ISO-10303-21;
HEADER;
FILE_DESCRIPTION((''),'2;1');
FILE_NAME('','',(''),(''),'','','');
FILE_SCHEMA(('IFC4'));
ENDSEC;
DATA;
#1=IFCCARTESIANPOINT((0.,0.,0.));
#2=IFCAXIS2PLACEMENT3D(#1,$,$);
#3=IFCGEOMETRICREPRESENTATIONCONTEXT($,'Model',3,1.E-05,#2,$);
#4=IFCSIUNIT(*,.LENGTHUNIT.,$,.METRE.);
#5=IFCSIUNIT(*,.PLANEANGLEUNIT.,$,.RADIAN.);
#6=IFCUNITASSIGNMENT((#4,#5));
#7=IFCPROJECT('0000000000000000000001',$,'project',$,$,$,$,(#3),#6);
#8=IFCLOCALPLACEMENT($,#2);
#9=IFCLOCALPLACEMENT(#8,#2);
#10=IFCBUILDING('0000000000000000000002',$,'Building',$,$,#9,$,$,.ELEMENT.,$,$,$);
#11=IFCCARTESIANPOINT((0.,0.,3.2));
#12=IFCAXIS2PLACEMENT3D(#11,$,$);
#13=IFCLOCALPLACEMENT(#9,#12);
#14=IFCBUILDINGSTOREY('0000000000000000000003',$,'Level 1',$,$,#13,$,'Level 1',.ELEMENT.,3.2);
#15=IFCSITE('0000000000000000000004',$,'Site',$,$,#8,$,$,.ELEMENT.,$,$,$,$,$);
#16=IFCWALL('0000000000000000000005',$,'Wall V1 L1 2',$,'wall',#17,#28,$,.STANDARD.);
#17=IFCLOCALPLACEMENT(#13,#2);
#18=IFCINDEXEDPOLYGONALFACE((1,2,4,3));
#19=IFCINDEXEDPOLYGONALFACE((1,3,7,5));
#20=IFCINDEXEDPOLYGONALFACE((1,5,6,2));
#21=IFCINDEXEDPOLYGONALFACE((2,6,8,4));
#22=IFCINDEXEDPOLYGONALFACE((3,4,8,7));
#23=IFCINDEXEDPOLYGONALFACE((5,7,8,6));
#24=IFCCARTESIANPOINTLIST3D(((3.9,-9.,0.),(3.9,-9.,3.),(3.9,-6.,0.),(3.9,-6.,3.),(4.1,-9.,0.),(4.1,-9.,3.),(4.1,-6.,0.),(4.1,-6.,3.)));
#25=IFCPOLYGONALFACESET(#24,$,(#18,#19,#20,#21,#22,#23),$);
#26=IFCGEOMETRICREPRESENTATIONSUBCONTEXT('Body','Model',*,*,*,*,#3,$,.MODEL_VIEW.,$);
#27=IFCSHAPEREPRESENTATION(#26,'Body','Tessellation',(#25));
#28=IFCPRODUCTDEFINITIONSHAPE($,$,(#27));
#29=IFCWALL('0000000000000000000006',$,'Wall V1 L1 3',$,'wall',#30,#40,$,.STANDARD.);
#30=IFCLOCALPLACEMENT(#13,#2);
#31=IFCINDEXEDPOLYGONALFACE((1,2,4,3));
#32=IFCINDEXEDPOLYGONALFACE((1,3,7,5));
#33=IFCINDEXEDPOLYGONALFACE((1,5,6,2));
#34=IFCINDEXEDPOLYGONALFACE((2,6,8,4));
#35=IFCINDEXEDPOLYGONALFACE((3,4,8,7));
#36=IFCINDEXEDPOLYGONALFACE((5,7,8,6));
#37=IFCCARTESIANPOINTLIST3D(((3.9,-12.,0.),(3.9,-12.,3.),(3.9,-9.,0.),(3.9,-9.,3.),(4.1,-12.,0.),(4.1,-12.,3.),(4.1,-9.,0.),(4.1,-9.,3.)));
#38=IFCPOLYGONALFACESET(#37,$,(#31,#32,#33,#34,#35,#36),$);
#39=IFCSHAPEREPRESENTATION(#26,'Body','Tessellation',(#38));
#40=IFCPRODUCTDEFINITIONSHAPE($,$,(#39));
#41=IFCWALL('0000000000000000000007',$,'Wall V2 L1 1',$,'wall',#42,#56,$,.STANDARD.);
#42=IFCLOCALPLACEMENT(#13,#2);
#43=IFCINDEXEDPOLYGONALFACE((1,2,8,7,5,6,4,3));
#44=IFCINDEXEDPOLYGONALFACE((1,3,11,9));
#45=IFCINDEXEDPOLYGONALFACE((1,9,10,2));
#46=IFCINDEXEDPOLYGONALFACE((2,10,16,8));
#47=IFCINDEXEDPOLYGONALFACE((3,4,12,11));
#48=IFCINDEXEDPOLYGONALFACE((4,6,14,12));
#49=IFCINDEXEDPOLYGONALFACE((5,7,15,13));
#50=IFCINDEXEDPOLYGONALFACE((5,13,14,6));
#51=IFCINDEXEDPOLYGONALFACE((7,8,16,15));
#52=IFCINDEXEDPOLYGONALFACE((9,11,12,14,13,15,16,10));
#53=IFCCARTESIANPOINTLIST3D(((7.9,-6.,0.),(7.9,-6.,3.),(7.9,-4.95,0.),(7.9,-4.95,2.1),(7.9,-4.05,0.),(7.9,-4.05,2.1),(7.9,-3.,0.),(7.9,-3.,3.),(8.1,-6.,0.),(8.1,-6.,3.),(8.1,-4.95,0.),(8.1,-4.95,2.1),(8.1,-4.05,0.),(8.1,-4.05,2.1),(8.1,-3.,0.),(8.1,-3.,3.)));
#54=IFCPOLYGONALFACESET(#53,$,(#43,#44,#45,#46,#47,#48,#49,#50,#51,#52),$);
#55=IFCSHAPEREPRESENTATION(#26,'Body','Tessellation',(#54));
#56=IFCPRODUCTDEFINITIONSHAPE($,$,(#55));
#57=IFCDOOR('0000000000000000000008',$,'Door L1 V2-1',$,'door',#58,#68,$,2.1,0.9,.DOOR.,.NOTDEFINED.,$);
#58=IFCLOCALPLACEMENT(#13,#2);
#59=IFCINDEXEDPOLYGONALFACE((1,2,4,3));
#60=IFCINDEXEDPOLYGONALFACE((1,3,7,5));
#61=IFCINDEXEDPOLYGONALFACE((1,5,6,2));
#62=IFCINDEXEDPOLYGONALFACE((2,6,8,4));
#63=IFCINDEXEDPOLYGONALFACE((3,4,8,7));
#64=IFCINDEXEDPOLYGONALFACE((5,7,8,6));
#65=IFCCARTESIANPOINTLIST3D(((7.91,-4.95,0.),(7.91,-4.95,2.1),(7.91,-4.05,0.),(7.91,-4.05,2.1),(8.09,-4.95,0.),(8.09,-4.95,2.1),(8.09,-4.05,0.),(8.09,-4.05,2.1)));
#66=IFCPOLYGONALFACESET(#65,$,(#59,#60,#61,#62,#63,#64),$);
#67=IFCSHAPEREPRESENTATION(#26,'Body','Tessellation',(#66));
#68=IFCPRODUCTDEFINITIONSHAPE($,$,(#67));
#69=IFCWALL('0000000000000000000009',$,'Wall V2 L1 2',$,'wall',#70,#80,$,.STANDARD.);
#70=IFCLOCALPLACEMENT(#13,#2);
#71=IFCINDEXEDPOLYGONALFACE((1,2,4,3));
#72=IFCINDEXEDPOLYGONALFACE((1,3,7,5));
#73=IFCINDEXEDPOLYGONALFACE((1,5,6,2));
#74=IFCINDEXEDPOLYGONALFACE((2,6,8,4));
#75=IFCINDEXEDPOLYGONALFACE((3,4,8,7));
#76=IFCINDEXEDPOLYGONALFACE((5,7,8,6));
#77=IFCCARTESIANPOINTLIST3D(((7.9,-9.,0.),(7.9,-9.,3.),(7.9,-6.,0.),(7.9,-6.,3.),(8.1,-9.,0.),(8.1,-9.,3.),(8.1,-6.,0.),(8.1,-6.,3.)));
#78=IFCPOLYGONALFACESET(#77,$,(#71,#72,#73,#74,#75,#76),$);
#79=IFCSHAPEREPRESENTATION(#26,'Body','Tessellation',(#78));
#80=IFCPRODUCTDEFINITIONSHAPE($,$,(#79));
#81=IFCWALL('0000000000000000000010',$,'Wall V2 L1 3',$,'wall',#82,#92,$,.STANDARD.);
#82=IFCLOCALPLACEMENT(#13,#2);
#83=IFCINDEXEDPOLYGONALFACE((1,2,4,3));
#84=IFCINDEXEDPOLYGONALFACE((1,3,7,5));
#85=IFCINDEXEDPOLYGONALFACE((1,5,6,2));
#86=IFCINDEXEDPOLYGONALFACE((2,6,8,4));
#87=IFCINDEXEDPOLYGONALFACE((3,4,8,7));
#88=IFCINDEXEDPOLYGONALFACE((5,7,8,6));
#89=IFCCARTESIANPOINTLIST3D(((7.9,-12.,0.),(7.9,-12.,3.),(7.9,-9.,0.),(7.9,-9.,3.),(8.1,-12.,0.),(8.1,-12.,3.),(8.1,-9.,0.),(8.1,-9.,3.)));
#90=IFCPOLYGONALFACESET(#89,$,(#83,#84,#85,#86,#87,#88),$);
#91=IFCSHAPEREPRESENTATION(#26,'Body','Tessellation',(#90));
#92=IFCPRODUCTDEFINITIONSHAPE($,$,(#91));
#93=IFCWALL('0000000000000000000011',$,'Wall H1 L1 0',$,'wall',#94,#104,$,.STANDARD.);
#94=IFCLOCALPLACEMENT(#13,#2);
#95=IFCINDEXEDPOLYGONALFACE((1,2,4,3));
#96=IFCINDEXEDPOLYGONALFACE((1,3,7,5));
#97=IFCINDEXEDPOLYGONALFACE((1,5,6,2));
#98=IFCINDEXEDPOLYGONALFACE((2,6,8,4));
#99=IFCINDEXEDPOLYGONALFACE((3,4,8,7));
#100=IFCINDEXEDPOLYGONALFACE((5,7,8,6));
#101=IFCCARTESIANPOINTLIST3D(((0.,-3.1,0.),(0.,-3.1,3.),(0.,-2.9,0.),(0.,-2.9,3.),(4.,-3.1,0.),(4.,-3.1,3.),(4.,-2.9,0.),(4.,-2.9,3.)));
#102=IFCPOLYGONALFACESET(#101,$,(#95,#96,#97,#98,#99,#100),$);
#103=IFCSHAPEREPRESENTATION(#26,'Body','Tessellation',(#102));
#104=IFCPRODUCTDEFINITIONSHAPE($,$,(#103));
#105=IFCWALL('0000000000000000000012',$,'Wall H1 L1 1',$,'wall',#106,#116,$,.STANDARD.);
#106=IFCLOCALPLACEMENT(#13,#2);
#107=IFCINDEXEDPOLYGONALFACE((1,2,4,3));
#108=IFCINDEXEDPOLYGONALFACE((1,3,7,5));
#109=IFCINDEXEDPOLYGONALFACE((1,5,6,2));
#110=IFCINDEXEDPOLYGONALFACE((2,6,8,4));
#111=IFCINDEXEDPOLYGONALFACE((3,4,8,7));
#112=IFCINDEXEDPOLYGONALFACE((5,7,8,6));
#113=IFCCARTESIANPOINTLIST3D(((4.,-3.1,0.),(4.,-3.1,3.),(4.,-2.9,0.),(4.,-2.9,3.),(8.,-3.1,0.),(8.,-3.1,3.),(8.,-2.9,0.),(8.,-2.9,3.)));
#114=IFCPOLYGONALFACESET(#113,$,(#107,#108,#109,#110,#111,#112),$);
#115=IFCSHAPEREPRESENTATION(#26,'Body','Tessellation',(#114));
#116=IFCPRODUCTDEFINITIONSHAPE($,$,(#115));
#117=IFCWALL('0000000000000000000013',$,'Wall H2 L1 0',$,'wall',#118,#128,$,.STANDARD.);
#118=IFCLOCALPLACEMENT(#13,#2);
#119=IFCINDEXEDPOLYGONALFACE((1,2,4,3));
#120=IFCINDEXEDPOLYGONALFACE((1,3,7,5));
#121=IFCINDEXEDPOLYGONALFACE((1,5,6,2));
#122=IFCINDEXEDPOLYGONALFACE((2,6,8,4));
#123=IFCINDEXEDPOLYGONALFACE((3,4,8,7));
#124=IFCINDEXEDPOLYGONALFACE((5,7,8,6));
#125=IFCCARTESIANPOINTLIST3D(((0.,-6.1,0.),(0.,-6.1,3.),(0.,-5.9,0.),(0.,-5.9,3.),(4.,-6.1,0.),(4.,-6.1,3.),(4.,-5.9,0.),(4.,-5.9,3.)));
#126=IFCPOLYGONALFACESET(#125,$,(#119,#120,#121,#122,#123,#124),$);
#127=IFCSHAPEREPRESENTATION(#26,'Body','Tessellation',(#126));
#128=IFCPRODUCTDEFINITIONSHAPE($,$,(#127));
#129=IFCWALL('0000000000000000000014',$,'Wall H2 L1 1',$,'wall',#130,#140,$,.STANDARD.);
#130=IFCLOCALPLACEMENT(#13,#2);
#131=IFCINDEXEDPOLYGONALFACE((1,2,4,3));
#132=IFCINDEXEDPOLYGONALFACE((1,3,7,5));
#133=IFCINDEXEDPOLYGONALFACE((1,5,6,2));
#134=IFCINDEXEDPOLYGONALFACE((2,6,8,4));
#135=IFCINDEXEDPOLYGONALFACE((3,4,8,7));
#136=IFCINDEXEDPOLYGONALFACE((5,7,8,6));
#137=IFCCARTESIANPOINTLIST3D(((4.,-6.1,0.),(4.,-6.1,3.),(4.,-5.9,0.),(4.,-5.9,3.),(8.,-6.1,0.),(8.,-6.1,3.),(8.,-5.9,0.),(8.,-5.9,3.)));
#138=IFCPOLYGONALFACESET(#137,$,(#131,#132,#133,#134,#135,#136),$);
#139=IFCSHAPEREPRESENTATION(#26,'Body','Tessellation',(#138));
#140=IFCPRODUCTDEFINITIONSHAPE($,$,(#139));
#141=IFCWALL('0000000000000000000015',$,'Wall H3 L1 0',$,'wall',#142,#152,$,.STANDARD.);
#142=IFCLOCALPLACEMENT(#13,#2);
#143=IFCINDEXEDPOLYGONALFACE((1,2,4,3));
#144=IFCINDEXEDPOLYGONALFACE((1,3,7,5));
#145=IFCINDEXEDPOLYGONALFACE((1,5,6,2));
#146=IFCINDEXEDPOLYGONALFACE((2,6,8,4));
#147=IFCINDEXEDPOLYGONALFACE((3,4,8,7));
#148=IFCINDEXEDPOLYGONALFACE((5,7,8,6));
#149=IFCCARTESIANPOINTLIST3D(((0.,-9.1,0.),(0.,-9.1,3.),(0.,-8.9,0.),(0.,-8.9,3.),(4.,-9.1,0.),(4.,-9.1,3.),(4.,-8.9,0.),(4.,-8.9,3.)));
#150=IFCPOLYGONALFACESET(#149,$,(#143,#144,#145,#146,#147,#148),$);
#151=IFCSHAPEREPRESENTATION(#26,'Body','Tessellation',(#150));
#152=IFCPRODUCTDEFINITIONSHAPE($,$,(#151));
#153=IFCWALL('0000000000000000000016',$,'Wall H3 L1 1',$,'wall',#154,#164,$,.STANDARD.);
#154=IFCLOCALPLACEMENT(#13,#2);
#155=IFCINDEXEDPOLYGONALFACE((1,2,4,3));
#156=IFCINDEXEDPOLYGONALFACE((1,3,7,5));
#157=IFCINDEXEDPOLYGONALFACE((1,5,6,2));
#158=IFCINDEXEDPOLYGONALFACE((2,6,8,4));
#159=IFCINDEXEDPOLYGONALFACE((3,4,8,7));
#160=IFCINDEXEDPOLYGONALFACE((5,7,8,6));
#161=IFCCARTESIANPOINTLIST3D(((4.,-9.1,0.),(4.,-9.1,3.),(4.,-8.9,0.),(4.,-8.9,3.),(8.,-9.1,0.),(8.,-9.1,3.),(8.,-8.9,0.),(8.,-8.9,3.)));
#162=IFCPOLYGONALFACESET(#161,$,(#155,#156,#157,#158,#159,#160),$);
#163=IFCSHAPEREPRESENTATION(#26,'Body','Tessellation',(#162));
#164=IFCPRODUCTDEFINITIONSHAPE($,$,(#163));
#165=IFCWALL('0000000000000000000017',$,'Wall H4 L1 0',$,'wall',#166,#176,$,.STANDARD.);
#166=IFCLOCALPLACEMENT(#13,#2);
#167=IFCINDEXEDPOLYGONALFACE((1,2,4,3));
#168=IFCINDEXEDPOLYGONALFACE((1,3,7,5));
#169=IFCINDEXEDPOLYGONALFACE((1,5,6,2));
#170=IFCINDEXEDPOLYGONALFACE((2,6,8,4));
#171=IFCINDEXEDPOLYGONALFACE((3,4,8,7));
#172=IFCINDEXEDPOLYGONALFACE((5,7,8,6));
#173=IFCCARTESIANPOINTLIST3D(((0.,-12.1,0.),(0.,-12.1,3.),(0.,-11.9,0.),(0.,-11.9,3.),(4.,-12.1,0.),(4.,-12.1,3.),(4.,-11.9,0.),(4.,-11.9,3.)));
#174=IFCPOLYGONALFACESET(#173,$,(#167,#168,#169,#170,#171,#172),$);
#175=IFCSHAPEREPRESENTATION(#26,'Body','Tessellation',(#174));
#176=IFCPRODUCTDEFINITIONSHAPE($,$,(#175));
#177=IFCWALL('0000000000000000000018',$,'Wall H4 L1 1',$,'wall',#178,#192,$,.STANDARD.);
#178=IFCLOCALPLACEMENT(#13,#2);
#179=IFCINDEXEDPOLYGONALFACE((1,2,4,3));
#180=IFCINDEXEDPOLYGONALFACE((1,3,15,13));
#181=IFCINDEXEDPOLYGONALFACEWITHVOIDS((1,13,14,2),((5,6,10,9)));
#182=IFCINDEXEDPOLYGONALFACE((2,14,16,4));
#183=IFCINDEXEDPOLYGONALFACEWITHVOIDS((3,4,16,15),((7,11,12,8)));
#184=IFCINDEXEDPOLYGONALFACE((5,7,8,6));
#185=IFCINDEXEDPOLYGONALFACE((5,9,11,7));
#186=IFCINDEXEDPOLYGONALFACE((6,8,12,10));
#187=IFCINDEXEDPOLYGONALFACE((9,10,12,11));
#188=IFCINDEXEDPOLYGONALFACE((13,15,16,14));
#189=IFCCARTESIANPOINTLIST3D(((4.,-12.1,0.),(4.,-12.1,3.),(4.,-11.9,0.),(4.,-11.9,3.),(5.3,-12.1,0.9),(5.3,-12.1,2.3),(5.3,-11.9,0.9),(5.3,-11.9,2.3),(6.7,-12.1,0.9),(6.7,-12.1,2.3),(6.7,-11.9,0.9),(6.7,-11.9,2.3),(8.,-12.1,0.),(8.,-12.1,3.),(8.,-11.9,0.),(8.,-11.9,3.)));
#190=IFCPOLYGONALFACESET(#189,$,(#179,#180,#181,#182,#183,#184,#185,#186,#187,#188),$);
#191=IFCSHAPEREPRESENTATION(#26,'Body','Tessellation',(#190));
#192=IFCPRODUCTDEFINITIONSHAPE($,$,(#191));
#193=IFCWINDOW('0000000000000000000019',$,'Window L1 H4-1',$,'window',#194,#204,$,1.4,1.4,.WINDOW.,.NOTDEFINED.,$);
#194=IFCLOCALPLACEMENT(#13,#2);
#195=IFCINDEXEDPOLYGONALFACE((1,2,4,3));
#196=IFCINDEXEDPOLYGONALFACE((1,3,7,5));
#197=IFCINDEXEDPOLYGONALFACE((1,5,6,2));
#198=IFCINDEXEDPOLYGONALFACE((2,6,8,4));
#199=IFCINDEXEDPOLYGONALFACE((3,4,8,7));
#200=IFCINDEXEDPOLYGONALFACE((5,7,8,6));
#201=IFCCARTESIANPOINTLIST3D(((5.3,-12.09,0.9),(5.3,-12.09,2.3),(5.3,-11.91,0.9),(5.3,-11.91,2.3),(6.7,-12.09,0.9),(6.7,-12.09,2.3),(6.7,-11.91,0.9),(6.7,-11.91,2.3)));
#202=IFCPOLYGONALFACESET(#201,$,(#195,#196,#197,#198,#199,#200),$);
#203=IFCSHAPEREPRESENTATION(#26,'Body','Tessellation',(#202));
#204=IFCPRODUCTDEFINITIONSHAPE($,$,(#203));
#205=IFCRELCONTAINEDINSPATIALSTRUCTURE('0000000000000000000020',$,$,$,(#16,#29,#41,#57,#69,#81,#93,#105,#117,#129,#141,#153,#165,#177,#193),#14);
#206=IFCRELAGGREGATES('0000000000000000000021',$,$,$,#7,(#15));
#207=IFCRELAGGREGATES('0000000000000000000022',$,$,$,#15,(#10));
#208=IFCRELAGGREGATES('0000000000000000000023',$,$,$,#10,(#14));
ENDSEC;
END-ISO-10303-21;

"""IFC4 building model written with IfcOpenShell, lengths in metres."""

from ifc_helpers import new_model, si_unit, frame, frame_2d, origin, origin_2d, place, context, subcontext, project, spatial, rectangle, extrude, element, fill, save


model = new_model("IFC4")

# Units and contexts
model_context = context("Model", 3, precision=1e-05, world=origin())
body_context = subcontext(model_context, "Body", "Model", "MODEL_VIEW")
ifc_project = project(units=[si_unit("LENGTHUNIT", "METRE"), si_unit("PLANEANGLEUNIT", "RADIAN")], contexts=[model_context])

# Site, building, storey
site_placement = place(None, origin())
site = spatial("IfcSite", under=ifc_project, at=site_placement, Name="Site", CompositionType="ELEMENT")
building_placement = place(site_placement, origin())
building = spatial("IfcBuilding", under=site, at=building_placement, Name="Building", CompositionType="ELEMENT")
storey_placement = place(building_placement, frame((0.0, 0.0, 3.2)))
storey = spatial("IfcBuildingStorey", under=building, at=storey_placement, Name="Level 1", LongName="Level 1", CompositionType="ELEMENT", Elevation=3.2)

# Walls
for number, where, z_axis, x_axis, name in (
    (1, (4.0, -6.0, 0.0), (0.0, 0.0, 1.0), (0.0, -1.0, 0.0), "Wall V1 L1 2"),
    (2, (4.0, -9.0, 0.0), (0.0, 0.0, 1.0), (0.0, -1.0, 0.0), "Wall V1 L1 3"),
):
    element("IfcWall", number, at=place(storey_placement, frame(where, z_axis=z_axis, x_axis=x_axis)), inside=storey, Name=name, ObjectType="wall", PredefinedType="STANDARD", context=body_context, shape_type="SweptSolid", body=[
        extrude(rectangle(XDim=3.0, YDim=0.2, at=frame_2d((1.5, 0.0))), origin(), (0.0, 0.0, 1.0), 3.0),
    ])

# Wall, opening, door
wall_1_placement = place(storey_placement, frame((8.0, -3.0, 0.0), z_axis=(0.0, 0.0, 1.0), x_axis=(0.0, -1.0, 0.0)))
wall_1 = element("IfcWall", 3, at=wall_1_placement, inside=storey, Name="Wall V2 L1 1", ObjectType="wall", PredefinedType="STANDARD", context=body_context, shape_type="SweptSolid", body=[
    extrude(rectangle(XDim=3.0, YDim=0.2, at=frame_2d((1.5, 0.0))), origin(), (0.0, 0.0, 1.0), 3.0),
])
opening_1_placement = place(storey_placement, frame((8.0, -4.5, 0.0), z_axis=(0.0, 0.0, 1.0), x_axis=(0.0, -1.0, 0.0)))
opening_1 = element("IfcOpeningElement", 4, at=opening_1_placement, cuts=wall_1, ObjectType="Opening", PredefinedType="OPENING", context=body_context, shape_type="SweptSolid", body=[
    extrude(rectangle(XDim=0.9, YDim=0.22, at=origin_2d()), origin(), (0.0, 0.0, 1.0), 2.1),
])
door_1_placement = place(storey_placement, frame((8.0, -4.5, 0.0), z_axis=(0.0, 0.0, 1.0), x_axis=(0.0, -1.0, 0.0)))
door_1 = element("IfcDoor", 5, at=door_1_placement, inside=storey, Name="Door L1 V2-1", ObjectType="door", OperationType="NOTDEFINED", OverallHeight=2.1, OverallWidth=0.9, PredefinedType="DOOR", context=body_context, shape_type="SweptSolid", body=[
    extrude(rectangle(XDim=0.9, YDim=0.18, at=origin_2d()), origin(), (0.0, 0.0, 1.0), 2.1),
])
fill(opening_1, door_1)

# Walls
for number, where, z_axis, x_axis, name in (
    (6, (8.0, -6.0, 0.0), (0.0, 0.0, 1.0), (0.0, -1.0, 0.0), "Wall V2 L1 2"),
    (7, (8.0, -9.0, 0.0), (0.0, 0.0, 1.0), (0.0, -1.0, 0.0), "Wall V2 L1 3"),
):
    element("IfcWall", number, at=place(storey_placement, frame(where, z_axis=z_axis, x_axis=x_axis)), inside=storey, Name=name, ObjectType="wall", PredefinedType="STANDARD", context=body_context, shape_type="SweptSolid", body=[
        extrude(rectangle(XDim=3.0, YDim=0.2, at=frame_2d((1.5, 0.0))), origin(), (0.0, 0.0, 1.0), 3.0),
    ])
for number, where, z_axis, x_axis, name in (
    (8, (0.0, -3.0, 0.0), (0.0, 0.0, 1.0), (1.0, 0.0, 0.0), "Wall H1 L1 0"),
    (9, (4.0, -3.0, 0.0), (0.0, 0.0, 1.0), (1.0, 0.0, 0.0), "Wall H1 L1 1"),
    (10, (0.0, -6.0, 0.0), (0.0, 0.0, 1.0), (1.0, 0.0, 0.0), "Wall H2 L1 0"),
    (11, (4.0, -6.0, 0.0), (0.0, 0.0, 1.0), (1.0, 0.0, 0.0), "Wall H2 L1 1"),
    (12, (0.0, -9.0, 0.0), (0.0, 0.0, 1.0), (1.0, 0.0, 0.0), "Wall H3 L1 0"),
    (13, (4.0, -9.0, 0.0), (0.0, 0.0, 1.0), (1.0, 0.0, 0.0), "Wall H3 L1 1"),
    (14, (0.0, -12.0, 0.0), (0.0, 0.0, 1.0), (1.0, 0.0, 0.0), "Wall H4 L1 0"),
):
    element("IfcWall", number, at=place(storey_placement, frame(where, z_axis=z_axis, x_axis=x_axis)), inside=storey, Name=name, ObjectType="wall", PredefinedType="STANDARD", context=body_context, shape_type="SweptSolid", body=[
        extrude(rectangle(XDim=4.0, YDim=0.2, at=frame_2d((2.0, 0.0))), origin(), (0.0, 0.0, 1.0), 3.0),
    ])

# Wall, opening, window
wall_2_placement = place(storey_placement, frame((4.0, -12.0, 0.0), z_axis=(0.0, 0.0, 1.0), x_axis=(1.0, 0.0, 0.0)))
wall_2 = element("IfcWall", 15, at=wall_2_placement, inside=storey, Name="Wall H4 L1 1", ObjectType="wall", PredefinedType="STANDARD", context=body_context, shape_type="SweptSolid", body=[
    extrude(rectangle(XDim=4.0, YDim=0.2, at=frame_2d((2.0, 0.0))), origin(), (0.0, 0.0, 1.0), 3.0),
])
opening_2_placement = place(storey_placement, frame((6.0, -12.0, 0.9), z_axis=(0.0, 0.0, 1.0), x_axis=(1.0, 0.0, 0.0)))
opening_2 = element("IfcOpeningElement", 16, at=opening_2_placement, cuts=wall_2, ObjectType="Opening", PredefinedType="OPENING", context=body_context, shape_type="SweptSolid", body=[
    extrude(rectangle(XDim=1.4, YDim=0.22, at=origin_2d()), origin(), (0.0, 0.0, 1.0), 1.4),
])
window_1_placement = place(storey_placement, frame((6.0, -12.0, 0.9), z_axis=(0.0, 0.0, 1.0), x_axis=(1.0, 0.0, 0.0)))
window_1 = element("IfcWindow", 17, at=window_1_placement, inside=storey, Name="Window L1 H4-1", ObjectType="window", OverallHeight=1.4, OverallWidth=1.4, PartitioningType="NOTDEFINED", PredefinedType="WINDOW", context=body_context, shape_type="SweptSolid", body=[
    extrude(rectangle(XDim=1.4, YDim=0.18, at=origin_2d()), origin(), (0.0, 0.0, 1.0), 1.4),
])
fill(opening_2, window_1)

save(model, "model.ifc")
